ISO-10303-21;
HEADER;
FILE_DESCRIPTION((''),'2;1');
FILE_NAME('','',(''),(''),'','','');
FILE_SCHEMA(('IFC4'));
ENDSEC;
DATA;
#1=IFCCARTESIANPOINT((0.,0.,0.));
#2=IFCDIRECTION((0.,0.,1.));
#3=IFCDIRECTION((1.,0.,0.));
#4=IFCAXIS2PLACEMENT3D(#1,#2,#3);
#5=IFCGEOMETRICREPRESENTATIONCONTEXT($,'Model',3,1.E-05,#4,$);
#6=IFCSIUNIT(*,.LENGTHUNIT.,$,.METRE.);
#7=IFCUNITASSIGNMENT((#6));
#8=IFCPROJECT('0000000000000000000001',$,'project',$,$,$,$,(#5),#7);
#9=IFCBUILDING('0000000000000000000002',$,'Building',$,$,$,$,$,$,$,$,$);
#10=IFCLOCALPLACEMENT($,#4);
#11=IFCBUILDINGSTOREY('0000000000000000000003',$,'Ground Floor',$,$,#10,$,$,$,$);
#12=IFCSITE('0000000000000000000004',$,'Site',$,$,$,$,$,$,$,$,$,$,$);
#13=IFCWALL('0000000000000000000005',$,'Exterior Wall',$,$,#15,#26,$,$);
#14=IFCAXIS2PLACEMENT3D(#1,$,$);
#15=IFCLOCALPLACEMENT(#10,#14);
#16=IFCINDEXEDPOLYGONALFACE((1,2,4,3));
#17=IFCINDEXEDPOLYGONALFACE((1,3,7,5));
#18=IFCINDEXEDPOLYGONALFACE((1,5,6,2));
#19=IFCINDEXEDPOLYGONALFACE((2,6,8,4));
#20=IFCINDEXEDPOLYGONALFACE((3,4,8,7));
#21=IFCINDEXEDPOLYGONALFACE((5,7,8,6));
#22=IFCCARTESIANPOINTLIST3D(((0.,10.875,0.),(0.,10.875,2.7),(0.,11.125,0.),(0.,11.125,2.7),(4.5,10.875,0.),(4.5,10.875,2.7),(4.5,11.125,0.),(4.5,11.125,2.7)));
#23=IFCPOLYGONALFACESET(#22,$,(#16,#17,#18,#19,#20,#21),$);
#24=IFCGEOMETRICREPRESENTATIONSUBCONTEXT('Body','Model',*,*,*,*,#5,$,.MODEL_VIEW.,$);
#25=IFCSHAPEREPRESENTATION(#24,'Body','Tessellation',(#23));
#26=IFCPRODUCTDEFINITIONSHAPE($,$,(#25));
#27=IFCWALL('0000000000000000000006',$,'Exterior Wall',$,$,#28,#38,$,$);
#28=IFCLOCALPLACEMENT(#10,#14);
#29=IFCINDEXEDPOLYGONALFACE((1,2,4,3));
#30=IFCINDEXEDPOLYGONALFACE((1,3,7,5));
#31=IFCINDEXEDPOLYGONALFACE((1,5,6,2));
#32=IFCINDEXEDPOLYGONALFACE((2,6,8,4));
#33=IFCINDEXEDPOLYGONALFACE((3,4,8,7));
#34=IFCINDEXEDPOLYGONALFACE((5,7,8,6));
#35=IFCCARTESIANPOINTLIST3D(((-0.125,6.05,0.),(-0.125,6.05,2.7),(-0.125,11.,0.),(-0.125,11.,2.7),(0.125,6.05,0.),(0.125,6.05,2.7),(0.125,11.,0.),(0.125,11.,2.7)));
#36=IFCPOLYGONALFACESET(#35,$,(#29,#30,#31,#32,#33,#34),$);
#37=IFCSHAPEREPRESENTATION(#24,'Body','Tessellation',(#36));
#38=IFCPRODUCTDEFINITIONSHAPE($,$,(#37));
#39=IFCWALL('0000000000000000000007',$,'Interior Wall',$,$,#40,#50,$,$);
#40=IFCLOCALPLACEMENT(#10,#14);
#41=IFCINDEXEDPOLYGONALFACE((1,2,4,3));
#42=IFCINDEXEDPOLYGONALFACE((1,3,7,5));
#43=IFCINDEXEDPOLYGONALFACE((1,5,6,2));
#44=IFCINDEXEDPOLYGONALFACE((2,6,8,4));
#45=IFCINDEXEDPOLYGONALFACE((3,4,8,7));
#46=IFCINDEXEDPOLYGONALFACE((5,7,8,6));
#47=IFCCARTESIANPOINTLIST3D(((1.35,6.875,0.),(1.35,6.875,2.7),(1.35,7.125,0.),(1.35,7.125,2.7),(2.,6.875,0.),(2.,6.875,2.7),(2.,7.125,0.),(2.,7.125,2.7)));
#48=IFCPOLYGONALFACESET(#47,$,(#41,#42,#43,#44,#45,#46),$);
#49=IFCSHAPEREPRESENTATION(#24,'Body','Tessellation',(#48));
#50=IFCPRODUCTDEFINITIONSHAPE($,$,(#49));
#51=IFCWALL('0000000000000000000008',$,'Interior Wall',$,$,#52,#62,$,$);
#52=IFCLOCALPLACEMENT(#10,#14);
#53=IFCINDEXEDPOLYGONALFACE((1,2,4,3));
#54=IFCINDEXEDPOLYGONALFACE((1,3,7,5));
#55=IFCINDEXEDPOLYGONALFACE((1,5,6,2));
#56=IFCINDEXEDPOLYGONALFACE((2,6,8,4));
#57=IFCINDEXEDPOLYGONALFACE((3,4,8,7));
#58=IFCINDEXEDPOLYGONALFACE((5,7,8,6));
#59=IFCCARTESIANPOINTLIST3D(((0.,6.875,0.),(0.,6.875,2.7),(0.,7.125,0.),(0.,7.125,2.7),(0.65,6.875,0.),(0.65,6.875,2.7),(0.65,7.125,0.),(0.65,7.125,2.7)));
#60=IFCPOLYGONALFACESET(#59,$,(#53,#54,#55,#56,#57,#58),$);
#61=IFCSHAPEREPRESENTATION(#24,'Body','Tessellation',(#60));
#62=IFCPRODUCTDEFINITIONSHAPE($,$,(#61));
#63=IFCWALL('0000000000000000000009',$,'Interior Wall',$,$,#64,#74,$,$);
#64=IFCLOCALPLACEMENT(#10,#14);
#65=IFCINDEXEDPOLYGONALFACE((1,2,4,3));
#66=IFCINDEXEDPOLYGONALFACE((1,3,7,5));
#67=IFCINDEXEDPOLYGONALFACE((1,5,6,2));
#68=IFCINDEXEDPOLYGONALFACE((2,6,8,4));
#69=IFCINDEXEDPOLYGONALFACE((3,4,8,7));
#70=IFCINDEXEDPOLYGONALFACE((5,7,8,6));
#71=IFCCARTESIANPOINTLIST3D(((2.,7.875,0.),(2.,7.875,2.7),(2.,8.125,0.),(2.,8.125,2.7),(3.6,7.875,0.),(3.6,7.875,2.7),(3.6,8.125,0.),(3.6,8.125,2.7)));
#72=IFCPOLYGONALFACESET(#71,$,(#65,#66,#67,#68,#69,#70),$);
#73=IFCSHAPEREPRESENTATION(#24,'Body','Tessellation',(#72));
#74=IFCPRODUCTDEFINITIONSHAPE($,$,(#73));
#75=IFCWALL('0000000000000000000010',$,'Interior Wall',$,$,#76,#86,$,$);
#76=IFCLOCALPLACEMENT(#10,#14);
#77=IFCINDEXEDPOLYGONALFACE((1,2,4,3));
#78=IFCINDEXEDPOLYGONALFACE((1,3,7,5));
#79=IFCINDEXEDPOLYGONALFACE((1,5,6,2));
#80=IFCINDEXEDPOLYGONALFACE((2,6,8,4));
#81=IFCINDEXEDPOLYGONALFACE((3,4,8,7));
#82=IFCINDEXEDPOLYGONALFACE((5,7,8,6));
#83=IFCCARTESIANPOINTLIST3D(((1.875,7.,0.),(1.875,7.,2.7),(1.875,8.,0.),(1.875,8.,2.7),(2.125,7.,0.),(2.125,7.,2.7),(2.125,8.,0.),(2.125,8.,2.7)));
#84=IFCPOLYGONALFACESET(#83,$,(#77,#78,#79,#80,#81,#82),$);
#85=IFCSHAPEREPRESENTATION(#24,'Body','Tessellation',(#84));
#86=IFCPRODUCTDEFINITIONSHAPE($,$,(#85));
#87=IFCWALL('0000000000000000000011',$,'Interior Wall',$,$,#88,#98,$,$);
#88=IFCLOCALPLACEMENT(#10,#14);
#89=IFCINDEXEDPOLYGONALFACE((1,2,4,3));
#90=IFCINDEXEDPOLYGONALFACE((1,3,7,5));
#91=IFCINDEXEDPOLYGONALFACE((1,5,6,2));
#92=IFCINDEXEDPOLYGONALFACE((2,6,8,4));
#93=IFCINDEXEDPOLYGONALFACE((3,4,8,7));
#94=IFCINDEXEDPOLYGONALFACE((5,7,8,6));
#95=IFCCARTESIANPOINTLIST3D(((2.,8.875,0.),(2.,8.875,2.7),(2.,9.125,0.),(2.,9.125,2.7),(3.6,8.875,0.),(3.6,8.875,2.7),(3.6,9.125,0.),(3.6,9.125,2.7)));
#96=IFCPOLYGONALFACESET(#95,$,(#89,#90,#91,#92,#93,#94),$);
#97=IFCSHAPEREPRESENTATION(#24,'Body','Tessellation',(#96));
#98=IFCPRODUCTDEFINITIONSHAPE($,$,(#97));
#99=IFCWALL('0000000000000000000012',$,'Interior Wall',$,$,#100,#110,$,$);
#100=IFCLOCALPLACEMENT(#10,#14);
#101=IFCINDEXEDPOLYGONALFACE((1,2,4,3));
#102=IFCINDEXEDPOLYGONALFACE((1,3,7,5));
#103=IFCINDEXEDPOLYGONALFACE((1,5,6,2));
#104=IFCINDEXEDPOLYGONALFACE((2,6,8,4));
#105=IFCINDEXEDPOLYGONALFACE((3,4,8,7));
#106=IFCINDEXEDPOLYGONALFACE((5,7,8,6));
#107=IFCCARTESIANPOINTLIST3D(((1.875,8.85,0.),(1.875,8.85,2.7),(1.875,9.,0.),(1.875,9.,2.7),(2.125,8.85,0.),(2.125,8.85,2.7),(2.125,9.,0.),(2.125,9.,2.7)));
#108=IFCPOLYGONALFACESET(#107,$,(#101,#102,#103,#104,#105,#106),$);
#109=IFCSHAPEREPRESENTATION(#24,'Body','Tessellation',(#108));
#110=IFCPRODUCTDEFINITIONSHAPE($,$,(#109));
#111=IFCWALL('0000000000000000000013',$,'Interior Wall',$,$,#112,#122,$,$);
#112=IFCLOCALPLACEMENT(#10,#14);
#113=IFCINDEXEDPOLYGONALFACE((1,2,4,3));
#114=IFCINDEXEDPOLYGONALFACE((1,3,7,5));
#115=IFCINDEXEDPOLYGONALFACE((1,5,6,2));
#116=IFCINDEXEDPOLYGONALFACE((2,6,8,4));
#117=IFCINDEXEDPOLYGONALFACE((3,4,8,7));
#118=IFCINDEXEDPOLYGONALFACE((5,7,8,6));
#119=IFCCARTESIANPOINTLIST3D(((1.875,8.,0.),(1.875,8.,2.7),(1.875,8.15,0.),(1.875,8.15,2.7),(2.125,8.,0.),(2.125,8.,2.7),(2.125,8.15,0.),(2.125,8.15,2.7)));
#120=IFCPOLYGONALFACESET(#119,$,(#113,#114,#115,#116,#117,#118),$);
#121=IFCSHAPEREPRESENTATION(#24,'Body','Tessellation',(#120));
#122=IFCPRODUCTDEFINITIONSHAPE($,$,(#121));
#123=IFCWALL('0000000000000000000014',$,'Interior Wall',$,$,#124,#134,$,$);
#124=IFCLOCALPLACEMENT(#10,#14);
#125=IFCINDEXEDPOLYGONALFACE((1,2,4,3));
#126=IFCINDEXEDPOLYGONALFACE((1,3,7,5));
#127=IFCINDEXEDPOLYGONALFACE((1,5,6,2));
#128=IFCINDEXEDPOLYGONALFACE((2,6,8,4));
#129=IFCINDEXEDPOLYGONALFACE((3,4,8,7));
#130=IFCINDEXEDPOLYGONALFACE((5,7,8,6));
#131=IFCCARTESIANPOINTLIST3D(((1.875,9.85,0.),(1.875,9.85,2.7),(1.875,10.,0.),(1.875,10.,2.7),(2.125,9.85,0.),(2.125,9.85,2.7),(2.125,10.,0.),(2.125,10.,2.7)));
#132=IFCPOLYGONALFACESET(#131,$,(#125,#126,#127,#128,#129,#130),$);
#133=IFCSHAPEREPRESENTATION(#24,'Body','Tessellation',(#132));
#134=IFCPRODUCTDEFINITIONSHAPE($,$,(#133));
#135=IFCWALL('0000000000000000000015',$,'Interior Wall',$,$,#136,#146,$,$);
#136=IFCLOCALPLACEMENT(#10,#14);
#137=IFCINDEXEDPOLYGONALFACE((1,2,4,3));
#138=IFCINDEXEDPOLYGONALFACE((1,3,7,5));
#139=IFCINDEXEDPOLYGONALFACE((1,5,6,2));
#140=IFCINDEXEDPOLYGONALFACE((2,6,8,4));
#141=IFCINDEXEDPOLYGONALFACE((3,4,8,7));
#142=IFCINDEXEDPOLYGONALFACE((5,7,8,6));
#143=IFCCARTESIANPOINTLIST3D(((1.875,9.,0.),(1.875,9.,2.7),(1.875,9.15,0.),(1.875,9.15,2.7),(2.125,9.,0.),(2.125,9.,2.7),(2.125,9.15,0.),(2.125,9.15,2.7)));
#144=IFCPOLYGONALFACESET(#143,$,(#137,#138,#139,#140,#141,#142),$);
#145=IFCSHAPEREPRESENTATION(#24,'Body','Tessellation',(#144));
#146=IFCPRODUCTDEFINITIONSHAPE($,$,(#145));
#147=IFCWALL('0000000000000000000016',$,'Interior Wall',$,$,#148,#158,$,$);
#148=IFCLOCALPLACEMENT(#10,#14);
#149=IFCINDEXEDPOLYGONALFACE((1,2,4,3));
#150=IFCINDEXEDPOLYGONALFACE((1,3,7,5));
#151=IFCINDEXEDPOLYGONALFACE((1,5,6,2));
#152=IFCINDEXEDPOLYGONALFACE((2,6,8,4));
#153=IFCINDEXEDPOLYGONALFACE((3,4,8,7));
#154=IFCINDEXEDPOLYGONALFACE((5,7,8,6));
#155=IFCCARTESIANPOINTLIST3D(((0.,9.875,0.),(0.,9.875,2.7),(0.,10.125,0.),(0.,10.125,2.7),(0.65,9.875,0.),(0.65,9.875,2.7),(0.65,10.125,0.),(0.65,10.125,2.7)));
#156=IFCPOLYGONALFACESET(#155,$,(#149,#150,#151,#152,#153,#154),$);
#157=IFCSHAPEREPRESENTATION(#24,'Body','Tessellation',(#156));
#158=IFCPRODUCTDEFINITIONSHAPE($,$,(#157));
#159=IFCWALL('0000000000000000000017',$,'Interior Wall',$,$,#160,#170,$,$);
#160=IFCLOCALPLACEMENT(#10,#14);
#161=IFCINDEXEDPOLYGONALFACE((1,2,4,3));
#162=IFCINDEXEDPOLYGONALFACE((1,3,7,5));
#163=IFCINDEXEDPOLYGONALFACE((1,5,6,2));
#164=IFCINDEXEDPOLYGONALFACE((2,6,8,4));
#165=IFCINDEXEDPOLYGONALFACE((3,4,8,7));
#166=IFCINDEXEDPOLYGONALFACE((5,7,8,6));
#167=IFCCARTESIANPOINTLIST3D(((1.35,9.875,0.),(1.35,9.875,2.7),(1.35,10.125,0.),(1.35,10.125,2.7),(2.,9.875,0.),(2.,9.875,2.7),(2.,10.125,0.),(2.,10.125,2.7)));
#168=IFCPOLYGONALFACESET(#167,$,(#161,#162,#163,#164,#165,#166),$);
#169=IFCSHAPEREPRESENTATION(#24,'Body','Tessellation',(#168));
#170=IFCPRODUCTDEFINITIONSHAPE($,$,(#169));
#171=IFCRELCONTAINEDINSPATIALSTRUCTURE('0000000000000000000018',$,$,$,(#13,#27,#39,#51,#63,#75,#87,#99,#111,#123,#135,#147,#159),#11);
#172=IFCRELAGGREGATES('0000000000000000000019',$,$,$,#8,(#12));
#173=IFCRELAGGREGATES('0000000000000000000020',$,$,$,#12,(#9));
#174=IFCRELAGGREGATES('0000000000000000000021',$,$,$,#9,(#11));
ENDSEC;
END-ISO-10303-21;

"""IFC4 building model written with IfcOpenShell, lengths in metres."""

from ifc_helpers import new_model, si_unit, frame, origin_with_axes, place, context, subcontext, project, spatial, indexed_curve, outline, extrude, element, save


model = new_model("IFC4")

# Units and contexts
model_context = context("Model", 3, precision=1e-05, world=origin_with_axes())
body_context = subcontext(model_context, "Body", "Model", "MODEL_VIEW")
ifc_project = project(units=[si_unit("LENGTHUNIT", "METRE")], contexts=[model_context])

# Site, building, storey
site = spatial("IfcSite", under=ifc_project, Name="Site")
building = spatial("IfcBuilding", under=site, Name="Building")
storey_placement = place(None, origin_with_axes())
storey = spatial("IfcBuildingStorey", under=building, at=storey_placement, Name="Ground Floor")

# Walls
wall_1_placement = place(storey_placement, frame((4.5, 11.0, 0.0), z_axis=(0.0, 0.0, 1.0), x_axis=(-1.0, 0.0, 0.0)))
element("IfcWall", 1, at=wall_1_placement, inside=storey, Name="Exterior Wall", context=body_context, shape_type="SweptSolid", body=[
    extrude(outline(indexed_curve([(0.0, 0.0), (0.0, 0.25), (4.5, 0.25), (4.5, 0.0), (0.0, 0.0)], self_intersect=False)), frame((0.0, -0.125, 0.0), z_axis=(0.0, 0.0, 1.0), x_axis=(1.0, 0.0, 0.0)), (0.0, 0.0, 1.0), 2.7),
])
wall_2_placement = place(storey_placement, frame((0.0, 11.0, 0.0), z_axis=(0.0, 0.0, 1.0), x_axis=(0.0, -1.0, 0.0)))
element("IfcWall", 2, at=wall_2_placement, inside=storey, Name="Exterior Wall", context=body_context, shape_type="SweptSolid", body=[
    extrude(outline(indexed_curve([(0.0, 0.0), (0.0, 0.25), (4.95, 0.25), (4.95, 0.0), (0.0, 0.0)], self_intersect=False)), frame((0.0, -0.125, 0.0), z_axis=(0.0, 0.0, 1.0), x_axis=(1.0, 0.0, 0.0)), (0.0, 0.0, 1.0), 2.7),
])
for number, where, z_axis, x_axis, name in (
    (3, (2.0, 7.0, 0.0), (0.0, 0.0, 1.0), (-1.0, 0.0, 0.0), "Interior Wall"),
    (4, (0.65, 7.0, 0.0), (0.0, 0.0, 1.0), (-1.0, 0.0, 0.0), "Interior Wall"),
):
    element("IfcWall", number, at=place(storey_placement, frame(where, z_axis=z_axis, x_axis=x_axis)), inside=storey, Name=name, context=body_context, shape_type="SweptSolid", body=[
        extrude(outline(indexed_curve([(0.0, 0.0), (0.0, 0.25), (0.65, 0.25), (0.65, 0.0), (0.0, 0.0)], self_intersect=False)), frame((0.0, -0.125, 0.0), z_axis=(0.0, 0.0, 1.0), x_axis=(1.0, 0.0, 0.0)), (0.0, 0.0, 1.0), 2.7),
    ])
wall_3_placement = place(storey_placement, frame((3.6, 8.0, 0.0), z_axis=(0.0, 0.0, 1.0), x_axis=(-1.0, 0.0, 0.0)))
element("IfcWall", 5, at=wall_3_placement, inside=storey, Name="Interior Wall", context=body_context, shape_type="SweptSolid", body=[
    extrude(outline(indexed_curve([(0.0, 0.0), (0.0, 0.25), (1.6, 0.25), (1.6, 0.0), (0.0, 0.0)], self_intersect=False)), frame((0.0, -0.125, 0.0), z_axis=(0.0, 0.0, 1.0), x_axis=(1.0, 0.0, 0.0)), (0.0, 0.0, 1.0), 2.7),
])
wall_4_placement = place(storey_placement, frame((2.0, 8.0, 0.0), z_axis=(0.0, 0.0, 1.0), x_axis=(0.0, -1.0, 0.0)))
element("IfcWall", 6, at=wall_4_placement, inside=storey, Name="Interior Wall", context=body_context, shape_type="SweptSolid", body=[
    extrude(outline(indexed_curve([(0.0, 0.0), (0.0, 0.25), (1.0, 0.25), (1.0, 0.0), (0.0, 0.0)], self_intersect=False)), frame((0.0, -0.125, 0.0), z_axis=(0.0, 0.0, 1.0), x_axis=(1.0, 0.0, 0.0)), (0.0, 0.0, 1.0), 2.7),
])
wall_5_placement = place(storey_placement, frame((3.6, 9.0, 0.0), z_axis=(0.0, 0.0, 1.0), x_axis=(-1.0, 0.0, 0.0)))
element("IfcWall", 7, at=wall_5_placement, inside=storey, Name="Interior Wall", context=body_context, shape_type="SweptSolid", body=[
    extrude(outline(indexed_curve([(0.0, 0.0), (0.0, 0.25), (1.6, 0.25), (1.6, 0.0), (0.0, 0.0)], self_intersect=False)), frame((0.0, -0.125, 0.0), z_axis=(0.0, 0.0, 1.0), x_axis=(1.0, 0.0, 0.0)), (0.0, 0.0, 1.0), 2.7),
])
for number, where, z_axis, x_axis, name in (
    (8, (2.0, 9.0, 0.0), (0.0, 0.0, 1.0), (0.0, -1.0, 0.0), "Interior Wall"),
    (9, (2.0, 8.15, 0.0), (0.0, 0.0, 1.0), (0.0, -1.0, 0.0), "Interior Wall"),
    (10, (2.0, 10.0, 0.0), (0.0, 0.0, 1.0), (0.0, -1.0, 0.0), "Interior Wall"),
    (11, (2.0, 9.15, 0.0), (0.0, 0.0, 1.0), (0.0, -1.0, 0.0), "Interior Wall"),
):
    element("IfcWall", number, at=place(storey_placement, frame(where, z_axis=z_axis, x_axis=x_axis)), inside=storey, Name=name, context=body_context, shape_type="SweptSolid", body=[
        extrude(outline(indexed_curve([(0.0, 0.0), (0.0, 0.25), (0.15, 0.25), (0.15, 0.0), (0.0, 0.0)], self_intersect=False)), frame((0.0, -0.125, 0.0), z_axis=(0.0, 0.0, 1.0), x_axis=(1.0, 0.0, 0.0)), (0.0, 0.0, 1.0), 2.7),
    ])
wall_6_placement = place(storey_placement, frame((0.0, 10.0, 0.0), z_axis=(0.0, 0.0, 1.0), x_axis=(1.0, 0.0, 0.0)))
element("IfcWall", 12, at=wall_6_placement, inside=storey, Name="Interior Wall", context=body_context, shape_type="SweptSolid", body=[
    extrude(outline(indexed_curve([(0.0, 0.0), (0.0, 0.25), (0.65, 0.25), (0.65, 0.0), (0.0, 0.0)], self_intersect=False)), frame((0.0, -0.125, 0.0), z_axis=(0.0, 0.0, 1.0), x_axis=(1.0, 0.0, 0.0)), (0.0, 0.0, 1.0), 2.7),
])
wall_7_placement = place(storey_placement, frame((1.35, 10.0, 0.0), z_axis=(0.0, 0.0, 1.0), x_axis=(1.0, 0.0, 0.0)))
element("IfcWall", 13, at=wall_7_placement, inside=storey, Name="Interior Wall", context=body_context, shape_type="SweptSolid", body=[
    extrude(outline(indexed_curve([(0.0, 0.0), (0.0, 0.25), (0.65, 0.25), (0.65, 0.0), (0.0, 0.0)], self_intersect=False)), frame((0.0, -0.125, 0.0), z_axis=(0.0, 0.0, 1.0), x_axis=(1.0, 0.0, 0.0)), (0.0, 0.0, 1.0), 2.7),
])

save(model, "model.ifc")
